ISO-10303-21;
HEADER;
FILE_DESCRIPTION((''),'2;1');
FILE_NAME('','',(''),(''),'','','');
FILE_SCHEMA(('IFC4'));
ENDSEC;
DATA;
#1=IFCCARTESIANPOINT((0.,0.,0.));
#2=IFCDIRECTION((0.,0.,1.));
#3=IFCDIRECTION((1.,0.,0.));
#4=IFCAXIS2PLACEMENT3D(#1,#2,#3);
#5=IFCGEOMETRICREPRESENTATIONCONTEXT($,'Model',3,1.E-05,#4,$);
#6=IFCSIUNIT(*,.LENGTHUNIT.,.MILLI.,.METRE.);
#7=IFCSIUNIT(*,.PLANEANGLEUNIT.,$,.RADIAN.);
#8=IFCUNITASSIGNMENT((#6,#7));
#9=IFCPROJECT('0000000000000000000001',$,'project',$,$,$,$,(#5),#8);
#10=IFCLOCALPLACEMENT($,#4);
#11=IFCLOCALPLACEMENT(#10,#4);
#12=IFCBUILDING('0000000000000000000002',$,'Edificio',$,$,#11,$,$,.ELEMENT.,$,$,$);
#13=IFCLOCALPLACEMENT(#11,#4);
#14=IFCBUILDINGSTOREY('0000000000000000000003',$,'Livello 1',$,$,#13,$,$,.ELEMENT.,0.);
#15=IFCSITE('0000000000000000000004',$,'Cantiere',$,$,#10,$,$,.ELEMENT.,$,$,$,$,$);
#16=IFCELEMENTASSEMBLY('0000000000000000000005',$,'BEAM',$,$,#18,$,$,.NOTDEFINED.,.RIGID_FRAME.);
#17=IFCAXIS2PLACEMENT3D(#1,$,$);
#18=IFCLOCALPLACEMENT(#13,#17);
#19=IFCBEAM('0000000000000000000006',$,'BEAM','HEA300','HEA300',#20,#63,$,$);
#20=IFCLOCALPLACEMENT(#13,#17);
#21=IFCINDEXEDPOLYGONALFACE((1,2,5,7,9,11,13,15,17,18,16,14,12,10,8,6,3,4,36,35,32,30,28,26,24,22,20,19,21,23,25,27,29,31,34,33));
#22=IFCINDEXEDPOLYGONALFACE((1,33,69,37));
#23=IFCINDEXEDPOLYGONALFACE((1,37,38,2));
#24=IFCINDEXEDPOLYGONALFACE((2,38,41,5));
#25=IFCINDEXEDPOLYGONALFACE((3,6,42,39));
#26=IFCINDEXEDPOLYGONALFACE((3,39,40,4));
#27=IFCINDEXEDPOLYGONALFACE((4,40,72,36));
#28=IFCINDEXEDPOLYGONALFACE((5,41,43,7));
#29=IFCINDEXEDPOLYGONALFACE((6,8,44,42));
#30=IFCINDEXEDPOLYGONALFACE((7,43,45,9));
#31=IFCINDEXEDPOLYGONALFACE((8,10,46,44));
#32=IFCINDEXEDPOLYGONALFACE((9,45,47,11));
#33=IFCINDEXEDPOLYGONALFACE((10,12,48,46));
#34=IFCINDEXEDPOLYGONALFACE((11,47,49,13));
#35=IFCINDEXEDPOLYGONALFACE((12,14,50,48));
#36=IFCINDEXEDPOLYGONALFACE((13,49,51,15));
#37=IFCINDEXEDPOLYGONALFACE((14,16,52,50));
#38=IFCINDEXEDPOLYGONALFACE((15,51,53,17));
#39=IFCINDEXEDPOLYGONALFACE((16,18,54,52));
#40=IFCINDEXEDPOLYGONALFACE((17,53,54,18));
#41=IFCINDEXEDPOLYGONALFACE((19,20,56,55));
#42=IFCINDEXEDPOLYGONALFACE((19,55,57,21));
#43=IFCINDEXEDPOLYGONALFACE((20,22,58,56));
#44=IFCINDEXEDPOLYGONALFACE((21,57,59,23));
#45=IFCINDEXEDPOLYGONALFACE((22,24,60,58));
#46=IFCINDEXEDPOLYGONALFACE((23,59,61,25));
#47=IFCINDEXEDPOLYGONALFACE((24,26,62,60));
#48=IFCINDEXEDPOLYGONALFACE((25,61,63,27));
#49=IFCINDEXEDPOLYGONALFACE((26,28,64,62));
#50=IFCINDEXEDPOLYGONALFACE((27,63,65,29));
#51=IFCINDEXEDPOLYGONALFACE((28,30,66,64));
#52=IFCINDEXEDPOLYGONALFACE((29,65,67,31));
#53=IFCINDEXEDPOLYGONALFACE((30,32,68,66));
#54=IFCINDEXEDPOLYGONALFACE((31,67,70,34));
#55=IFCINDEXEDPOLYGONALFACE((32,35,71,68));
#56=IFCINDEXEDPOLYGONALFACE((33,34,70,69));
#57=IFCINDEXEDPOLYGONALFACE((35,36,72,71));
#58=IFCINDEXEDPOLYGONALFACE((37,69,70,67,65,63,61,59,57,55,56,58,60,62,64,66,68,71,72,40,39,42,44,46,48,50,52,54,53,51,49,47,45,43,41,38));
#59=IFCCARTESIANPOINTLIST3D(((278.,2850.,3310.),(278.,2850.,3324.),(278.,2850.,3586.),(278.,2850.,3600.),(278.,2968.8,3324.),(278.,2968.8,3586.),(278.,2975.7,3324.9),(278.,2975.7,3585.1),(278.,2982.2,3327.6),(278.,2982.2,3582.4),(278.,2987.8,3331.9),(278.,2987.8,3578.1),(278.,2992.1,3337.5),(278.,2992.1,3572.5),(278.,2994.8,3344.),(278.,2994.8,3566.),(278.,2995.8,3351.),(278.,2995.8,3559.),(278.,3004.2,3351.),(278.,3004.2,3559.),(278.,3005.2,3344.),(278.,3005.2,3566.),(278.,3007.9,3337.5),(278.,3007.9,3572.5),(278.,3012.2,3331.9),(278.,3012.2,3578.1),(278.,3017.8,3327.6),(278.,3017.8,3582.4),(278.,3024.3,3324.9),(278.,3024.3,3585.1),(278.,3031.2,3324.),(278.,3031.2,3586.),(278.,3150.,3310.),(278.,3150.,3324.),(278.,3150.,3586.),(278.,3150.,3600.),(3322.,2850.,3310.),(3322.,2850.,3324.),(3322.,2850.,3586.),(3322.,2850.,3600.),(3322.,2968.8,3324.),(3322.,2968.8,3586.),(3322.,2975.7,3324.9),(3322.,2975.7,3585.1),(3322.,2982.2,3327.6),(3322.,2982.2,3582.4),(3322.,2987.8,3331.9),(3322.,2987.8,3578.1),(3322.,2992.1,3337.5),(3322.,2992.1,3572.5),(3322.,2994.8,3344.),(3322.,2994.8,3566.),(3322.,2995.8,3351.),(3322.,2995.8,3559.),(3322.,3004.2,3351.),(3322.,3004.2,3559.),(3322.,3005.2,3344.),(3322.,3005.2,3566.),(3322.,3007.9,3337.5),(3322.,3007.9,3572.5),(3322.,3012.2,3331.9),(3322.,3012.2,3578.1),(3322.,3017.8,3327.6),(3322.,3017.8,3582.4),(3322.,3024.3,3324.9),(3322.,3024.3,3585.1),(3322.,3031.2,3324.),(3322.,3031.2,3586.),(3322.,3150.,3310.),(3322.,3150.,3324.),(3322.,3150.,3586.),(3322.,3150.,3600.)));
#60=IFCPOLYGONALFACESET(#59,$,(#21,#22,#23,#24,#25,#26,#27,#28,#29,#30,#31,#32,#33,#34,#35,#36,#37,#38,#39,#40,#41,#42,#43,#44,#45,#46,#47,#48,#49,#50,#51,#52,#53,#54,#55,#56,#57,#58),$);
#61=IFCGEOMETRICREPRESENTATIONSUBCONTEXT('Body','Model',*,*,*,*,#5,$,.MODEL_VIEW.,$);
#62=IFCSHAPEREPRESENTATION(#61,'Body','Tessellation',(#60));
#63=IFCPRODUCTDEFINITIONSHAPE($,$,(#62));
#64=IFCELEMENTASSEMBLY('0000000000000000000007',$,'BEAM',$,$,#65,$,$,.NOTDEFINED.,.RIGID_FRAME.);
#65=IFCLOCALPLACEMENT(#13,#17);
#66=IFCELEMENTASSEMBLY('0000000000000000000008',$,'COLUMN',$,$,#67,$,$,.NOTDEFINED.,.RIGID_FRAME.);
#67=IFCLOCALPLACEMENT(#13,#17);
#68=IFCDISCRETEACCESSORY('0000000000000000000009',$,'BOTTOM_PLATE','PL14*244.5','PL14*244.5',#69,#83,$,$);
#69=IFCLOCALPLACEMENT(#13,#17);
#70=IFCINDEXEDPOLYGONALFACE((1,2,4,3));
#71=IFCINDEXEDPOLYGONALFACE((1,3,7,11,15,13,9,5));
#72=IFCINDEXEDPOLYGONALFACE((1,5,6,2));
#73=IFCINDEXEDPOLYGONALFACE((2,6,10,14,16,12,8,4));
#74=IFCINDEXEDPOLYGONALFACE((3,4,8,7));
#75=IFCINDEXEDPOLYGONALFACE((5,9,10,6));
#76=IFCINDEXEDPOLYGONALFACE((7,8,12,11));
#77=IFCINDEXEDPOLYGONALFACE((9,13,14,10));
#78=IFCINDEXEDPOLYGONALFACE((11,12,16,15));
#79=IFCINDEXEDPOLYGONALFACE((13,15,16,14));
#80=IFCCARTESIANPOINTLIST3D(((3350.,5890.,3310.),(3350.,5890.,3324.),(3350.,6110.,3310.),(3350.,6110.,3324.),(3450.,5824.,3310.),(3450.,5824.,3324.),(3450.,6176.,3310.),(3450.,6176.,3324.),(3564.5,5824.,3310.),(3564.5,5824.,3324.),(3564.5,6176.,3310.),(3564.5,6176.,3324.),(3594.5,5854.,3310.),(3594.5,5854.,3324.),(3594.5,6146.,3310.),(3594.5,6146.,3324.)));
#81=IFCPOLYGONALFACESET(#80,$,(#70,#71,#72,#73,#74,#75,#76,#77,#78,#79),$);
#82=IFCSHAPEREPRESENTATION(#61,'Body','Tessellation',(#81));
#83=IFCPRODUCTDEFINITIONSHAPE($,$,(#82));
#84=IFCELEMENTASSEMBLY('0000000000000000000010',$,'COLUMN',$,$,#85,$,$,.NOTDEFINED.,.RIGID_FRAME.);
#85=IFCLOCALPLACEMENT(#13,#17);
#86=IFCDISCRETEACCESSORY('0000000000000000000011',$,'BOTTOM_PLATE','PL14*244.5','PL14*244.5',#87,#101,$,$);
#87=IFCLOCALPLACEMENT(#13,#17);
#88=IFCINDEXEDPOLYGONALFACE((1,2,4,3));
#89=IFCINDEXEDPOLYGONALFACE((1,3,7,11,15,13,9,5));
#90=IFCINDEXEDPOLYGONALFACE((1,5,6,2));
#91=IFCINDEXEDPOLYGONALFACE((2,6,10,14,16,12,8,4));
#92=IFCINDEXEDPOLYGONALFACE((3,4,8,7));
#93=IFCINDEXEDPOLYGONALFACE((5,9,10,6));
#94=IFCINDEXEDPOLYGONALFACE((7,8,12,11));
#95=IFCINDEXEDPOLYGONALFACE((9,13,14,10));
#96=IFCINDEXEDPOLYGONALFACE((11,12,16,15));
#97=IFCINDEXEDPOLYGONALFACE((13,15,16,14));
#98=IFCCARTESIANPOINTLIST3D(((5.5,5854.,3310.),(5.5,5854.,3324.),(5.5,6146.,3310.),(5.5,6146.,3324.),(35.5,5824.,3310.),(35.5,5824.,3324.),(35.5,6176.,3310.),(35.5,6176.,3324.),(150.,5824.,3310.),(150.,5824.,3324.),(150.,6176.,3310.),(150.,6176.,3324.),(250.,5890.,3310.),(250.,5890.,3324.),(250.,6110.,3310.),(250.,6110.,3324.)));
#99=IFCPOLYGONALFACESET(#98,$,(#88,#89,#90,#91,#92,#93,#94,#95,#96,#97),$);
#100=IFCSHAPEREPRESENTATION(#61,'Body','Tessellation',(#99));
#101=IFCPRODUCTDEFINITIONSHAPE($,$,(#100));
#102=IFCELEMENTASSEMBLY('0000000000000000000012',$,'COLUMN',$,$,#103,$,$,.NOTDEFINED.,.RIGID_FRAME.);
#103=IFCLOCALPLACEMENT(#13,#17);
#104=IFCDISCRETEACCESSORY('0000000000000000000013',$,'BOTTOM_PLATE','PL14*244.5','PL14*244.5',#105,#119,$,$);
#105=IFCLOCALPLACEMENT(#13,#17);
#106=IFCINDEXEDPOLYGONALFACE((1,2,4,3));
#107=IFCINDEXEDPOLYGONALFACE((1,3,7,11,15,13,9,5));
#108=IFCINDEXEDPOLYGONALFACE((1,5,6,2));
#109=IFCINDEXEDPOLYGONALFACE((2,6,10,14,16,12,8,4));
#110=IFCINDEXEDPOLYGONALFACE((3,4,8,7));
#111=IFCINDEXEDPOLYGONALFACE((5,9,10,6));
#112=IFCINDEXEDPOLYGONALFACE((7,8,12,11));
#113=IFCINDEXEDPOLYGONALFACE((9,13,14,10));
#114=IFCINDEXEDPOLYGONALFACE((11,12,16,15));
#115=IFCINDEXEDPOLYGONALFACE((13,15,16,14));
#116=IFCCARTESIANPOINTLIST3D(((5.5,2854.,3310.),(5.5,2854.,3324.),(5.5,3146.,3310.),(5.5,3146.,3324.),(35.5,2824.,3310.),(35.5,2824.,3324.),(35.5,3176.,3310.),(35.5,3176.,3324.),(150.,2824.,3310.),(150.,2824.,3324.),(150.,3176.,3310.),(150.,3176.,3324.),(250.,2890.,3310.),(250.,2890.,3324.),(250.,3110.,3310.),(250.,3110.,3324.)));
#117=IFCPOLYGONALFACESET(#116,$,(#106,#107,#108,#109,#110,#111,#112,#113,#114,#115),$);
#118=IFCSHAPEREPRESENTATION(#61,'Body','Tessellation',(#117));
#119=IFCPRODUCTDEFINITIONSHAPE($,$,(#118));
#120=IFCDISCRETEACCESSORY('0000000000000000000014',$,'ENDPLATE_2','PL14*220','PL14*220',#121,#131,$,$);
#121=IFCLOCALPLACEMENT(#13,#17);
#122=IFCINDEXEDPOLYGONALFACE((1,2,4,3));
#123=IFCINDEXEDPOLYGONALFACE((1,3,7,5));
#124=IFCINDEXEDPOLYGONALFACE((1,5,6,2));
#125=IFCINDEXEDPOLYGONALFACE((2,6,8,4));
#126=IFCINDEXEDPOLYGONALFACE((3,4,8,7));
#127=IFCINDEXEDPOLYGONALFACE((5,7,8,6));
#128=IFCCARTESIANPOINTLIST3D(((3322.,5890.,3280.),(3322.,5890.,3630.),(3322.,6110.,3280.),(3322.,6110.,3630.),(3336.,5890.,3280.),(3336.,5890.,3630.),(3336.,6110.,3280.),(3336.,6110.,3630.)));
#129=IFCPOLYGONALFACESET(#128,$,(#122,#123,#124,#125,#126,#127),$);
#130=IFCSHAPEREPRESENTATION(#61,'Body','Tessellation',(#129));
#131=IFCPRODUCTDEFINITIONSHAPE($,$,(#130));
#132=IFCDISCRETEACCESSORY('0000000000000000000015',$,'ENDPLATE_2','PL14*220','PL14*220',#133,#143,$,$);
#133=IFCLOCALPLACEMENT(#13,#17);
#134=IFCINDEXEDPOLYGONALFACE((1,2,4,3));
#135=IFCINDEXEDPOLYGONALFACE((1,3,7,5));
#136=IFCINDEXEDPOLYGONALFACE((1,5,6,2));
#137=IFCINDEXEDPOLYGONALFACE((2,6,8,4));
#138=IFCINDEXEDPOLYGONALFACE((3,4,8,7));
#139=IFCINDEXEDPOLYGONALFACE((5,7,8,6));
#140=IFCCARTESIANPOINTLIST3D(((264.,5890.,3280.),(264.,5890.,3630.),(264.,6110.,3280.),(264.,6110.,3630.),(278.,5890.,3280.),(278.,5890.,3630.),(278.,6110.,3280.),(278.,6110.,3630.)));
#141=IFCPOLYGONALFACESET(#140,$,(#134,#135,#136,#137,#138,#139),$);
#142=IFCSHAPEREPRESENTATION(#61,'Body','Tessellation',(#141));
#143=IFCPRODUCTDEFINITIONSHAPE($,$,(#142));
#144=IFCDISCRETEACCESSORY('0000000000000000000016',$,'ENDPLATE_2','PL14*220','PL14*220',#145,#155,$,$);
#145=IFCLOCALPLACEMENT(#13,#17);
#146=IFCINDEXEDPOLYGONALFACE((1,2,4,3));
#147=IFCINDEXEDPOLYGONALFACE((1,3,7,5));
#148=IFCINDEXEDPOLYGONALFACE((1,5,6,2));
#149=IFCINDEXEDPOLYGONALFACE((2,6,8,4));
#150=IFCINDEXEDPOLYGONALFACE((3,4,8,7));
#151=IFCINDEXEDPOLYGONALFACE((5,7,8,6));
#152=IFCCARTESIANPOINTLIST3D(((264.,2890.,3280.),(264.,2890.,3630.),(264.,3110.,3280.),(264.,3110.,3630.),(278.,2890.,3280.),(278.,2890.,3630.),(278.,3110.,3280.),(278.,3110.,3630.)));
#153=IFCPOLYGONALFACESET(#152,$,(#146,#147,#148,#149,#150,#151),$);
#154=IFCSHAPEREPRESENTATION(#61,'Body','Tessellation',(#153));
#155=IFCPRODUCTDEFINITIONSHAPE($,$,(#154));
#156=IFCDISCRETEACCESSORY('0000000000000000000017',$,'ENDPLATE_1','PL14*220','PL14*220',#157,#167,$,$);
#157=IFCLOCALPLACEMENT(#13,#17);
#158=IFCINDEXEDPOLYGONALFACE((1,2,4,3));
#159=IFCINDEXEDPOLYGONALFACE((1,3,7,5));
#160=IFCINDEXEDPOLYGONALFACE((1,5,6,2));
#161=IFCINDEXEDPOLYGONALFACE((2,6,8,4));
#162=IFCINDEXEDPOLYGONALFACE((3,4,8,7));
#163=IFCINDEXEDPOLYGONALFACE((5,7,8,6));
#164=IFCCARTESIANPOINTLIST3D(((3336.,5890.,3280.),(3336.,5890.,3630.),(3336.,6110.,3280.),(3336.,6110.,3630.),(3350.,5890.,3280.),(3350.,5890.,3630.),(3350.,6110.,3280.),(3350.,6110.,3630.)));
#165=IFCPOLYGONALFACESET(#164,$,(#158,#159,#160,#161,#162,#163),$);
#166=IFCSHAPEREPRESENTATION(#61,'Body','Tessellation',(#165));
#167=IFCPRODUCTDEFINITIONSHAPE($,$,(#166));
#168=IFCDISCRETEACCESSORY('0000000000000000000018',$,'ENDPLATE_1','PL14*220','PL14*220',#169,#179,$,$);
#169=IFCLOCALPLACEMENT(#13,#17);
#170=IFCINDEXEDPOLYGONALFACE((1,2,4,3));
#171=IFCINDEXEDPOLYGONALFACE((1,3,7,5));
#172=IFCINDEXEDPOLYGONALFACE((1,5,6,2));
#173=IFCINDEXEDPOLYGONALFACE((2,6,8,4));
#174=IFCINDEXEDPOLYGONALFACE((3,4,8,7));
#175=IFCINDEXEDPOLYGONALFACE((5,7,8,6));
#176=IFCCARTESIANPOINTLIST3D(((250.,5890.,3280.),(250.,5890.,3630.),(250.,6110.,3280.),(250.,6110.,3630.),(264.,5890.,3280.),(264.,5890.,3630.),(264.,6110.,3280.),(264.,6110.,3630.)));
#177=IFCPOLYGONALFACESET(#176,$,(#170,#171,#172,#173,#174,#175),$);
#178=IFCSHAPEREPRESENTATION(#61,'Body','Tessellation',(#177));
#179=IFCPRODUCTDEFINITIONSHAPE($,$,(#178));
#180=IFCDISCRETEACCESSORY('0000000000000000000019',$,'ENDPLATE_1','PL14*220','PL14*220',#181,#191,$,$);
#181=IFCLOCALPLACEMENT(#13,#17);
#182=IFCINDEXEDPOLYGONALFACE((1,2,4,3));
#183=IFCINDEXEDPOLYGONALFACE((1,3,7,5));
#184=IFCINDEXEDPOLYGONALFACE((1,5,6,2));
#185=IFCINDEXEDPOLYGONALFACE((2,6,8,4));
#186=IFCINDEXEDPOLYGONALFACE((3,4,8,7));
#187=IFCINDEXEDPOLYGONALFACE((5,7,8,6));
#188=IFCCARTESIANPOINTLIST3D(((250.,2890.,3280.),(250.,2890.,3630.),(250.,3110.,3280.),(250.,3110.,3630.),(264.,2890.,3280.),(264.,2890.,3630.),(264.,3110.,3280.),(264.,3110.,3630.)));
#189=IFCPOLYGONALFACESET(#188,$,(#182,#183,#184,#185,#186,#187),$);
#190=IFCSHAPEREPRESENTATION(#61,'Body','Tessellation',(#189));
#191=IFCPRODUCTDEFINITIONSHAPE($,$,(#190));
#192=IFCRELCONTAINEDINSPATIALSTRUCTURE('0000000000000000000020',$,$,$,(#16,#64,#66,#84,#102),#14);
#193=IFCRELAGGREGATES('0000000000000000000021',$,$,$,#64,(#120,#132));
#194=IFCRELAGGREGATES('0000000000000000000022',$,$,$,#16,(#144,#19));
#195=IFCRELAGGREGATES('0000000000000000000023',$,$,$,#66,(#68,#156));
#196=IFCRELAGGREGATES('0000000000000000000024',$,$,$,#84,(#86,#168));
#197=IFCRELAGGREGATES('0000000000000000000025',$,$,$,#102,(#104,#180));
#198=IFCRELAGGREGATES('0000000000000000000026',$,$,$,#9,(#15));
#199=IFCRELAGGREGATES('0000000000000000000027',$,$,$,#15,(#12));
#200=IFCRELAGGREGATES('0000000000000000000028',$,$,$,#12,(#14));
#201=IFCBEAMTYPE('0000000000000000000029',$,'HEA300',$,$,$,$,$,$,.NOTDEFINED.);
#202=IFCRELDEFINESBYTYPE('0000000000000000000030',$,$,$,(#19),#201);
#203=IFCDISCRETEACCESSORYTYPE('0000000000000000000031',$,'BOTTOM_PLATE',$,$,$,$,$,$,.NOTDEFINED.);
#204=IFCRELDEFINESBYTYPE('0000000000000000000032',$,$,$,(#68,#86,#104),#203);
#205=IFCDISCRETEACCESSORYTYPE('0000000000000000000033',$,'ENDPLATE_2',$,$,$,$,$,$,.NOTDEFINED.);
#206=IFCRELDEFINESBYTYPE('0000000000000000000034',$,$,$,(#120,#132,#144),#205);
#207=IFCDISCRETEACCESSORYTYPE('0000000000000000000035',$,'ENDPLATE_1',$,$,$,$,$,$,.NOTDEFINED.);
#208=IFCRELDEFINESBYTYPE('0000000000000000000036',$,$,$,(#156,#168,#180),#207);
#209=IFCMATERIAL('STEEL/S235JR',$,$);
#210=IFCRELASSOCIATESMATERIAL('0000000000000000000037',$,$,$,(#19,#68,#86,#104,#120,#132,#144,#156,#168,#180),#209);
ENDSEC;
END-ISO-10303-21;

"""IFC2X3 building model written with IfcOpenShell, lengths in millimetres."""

from ifc_helpers import new_model, si_unit, frame, origin_with_axes, origin_2d_with_axis, place, context, subcontext, project, spatial, polyline, i_section, outline, extrude, clip, halfspace, material, type_object, element, aggregate, save


model = new_model("IFC2X3")

# Units and contexts
model_context = context("Model", 3, precision=1e-05, world=origin_with_axes())
body_context = subcontext(model_context, "Body", "Model", "MODEL_VIEW")
ifc_project = project(units=[si_unit("LENGTHUNIT", "METRE", prefix="MILLI"), si_unit("PLANEANGLEUNIT", "RADIAN")], contexts=[model_context])

# Site, building, storey
site_placement = place(None, origin_with_axes())
site = spatial("IfcSite", under=ifc_project, at=site_placement, Name="Cantiere", CompositionType="ELEMENT")
building_placement = place(site_placement, origin_with_axes())
building = spatial("IfcBuilding", under=site, at=building_placement, Name="Edificio", CompositionType="ELEMENT")
storey_placement = place(building_placement, origin_with_axes())
storey = spatial("IfcBuildingStorey", under=building, at=storey_placement, Name="Livello 1", CompositionType="ELEMENT", Elevation=0.0)

# Element assembly, beam
ifc_material_1 = material(Name="STEEL/S235JR")
beam_type = type_object("IfcBeamType", Name="HEA300", PredefinedType="NOTDEFINED")
assembly_1_placement = place(storey_placement, origin_with_axes())
assembly_1 = element("IfcElementAssembly", 1, at=assembly_1_placement, inside=storey, Name="BEAM", AssemblyPlace="NOTDEFINED", PredefinedType="RIGID_FRAME")
beam_1_placement = place(assembly_1_placement, frame((0.0, 3000.0, 3455.0), z_axis=(0.0, 0.0, 1.0), x_axis=(1.0, 0.0, 0.0)))
beam_1 = element("IfcBeam", 2, at=beam_1_placement, type_object=beam_type, material=ifc_material_1, Name="BEAM", Description="HEA300", ObjectType="HEA300", context=body_context, shape_type="Clipping", body=[
    clip(clip(extrude(i_section(OverallWidth=300.0, OverallDepth=290.0, WebThickness=8.5, FlangeThickness=14.0, FilletRadius=27.0, at=origin_2d_with_axis()), frame((3322.0, 0.0, 0.0), z_axis=(-1.0, 0.0, 0.0), x_axis=(0.0, -1.0, 0.0)), (0.0, 0.0, 1.0), 3044.0), halfspace(frame((3322.0, -150.0, 0.0), z_axis=(1.0, 0.0, 0.0), x_axis=(0.0, 0.0, 1.0)), False)), halfspace(frame((278.0, 150.0, 0.0), z_axis=(-1.0, 0.0, 0.0), x_axis=(0.0, 0.0, 1.0)), False)),
])

# Element assembly
assembly_2_placement = place(storey_placement, origin_with_axes())
assembly_2 = element("IfcElementAssembly", 3, at=assembly_2_placement, inside=storey, Name="BEAM", AssemblyPlace="NOTDEFINED", PredefinedType="RIGID_FRAME")

# Element assemblies, discrete accessories
assembly_3_placement = place(storey_placement, origin_with_axes())
assembly_3 = element("IfcElementAssembly", 4, at=assembly_3_placement, inside=storey, Name="COLUMN", AssemblyPlace="NOTDEFINED", PredefinedType="RIGID_FRAME")
discrete_accessory_type_1 = type_object("IfcDiscreteAccessoryType", Name="BOTTOM_PLATE")
discrete_accessory_1_placement = place(assembly_3_placement, frame((3594.5, 5824.0, 3317.0), z_axis=(0.0, 0.0, 1.0), x_axis=(0.0, 1.0, 0.0)))
discrete_accessory_1 = element("IfcDiscreteAccessory", 5, at=discrete_accessory_1_placement, type_object=discrete_accessory_type_1, material=ifc_material_1, Name="BOTTOM_PLATE", Description="PL14*244.5", ObjectType="PL14*244.5", context=body_context, shape_type="SweptSolid", body=[
    extrude(outline(polyline([(0.0, 30.0), (30.0, 0.0), (322.0, 0.0), (352.0, 30.0), (352.0, 144.5), (286.0, 244.5), (66.0, 244.5), (0.0, 144.5), (0.0, 30.0)])), frame((0.0, 0.0, -7.0), z_axis=(0.0, 0.0, 1.0), x_axis=(1.0, 0.0, 0.0)), (0.0, 0.0, 1.0), 14.0),
])
assembly_4_placement = place(storey_placement, origin_with_axes())
assembly_4 = element("IfcElementAssembly", 6, at=assembly_4_placement, inside=storey, Name="COLUMN", AssemblyPlace="NOTDEFINED", PredefinedType="RIGID_FRAME")
discrete_accessory_2_placement = place(assembly_4_placement, frame((5.5, 6176.0, 3317.0), z_axis=(0.0, 0.0, 1.0), x_axis=(0.0, -1.0, 0.0)))
discrete_accessory_2 = element("IfcDiscreteAccessory", 7, at=discrete_accessory_2_placement, type_object=discrete_accessory_type_1, material=ifc_material_1, Name="BOTTOM_PLATE", Description="PL14*244.5", ObjectType="PL14*244.5", context=body_context, shape_type="SweptSolid", body=[
    extrude(outline(polyline([(0.0, 30.0), (30.0, 0.0), (322.0, 0.0), (352.0, 30.0), (352.0, 144.5), (286.0, 244.5), (66.0, 244.5), (0.0, 144.5), (0.0, 30.0)])), frame((0.0, 0.0, -7.0), z_axis=(0.0, 0.0, 1.0), x_axis=(1.0, 0.0, 0.0)), (0.0, 0.0, 1.0), 14.0),
])
assembly_5_placement = place(storey_placement, origin_with_axes())
assembly_5 = element("IfcElementAssembly", 8, at=assembly_5_placement, inside=storey, Name="COLUMN", AssemblyPlace="NOTDEFINED", PredefinedType="RIGID_FRAME")
discrete_accessory_3_placement = place(assembly_5_placement, frame((5.5, 3176.0, 3317.0), z_axis=(0.0, 0.0, 1.0), x_axis=(0.0, -1.0, 0.0)))
discrete_accessory_3 = element("IfcDiscreteAccessory", 9, at=discrete_accessory_3_placement, type_object=discrete_accessory_type_1, material=ifc_material_1, Name="BOTTOM_PLATE", Description="PL14*244.5", ObjectType="PL14*244.5", context=body_context, shape_type="SweptSolid", body=[
    extrude(outline(polyline([(0.0, 30.0), (30.0, 0.0), (322.0, 0.0), (352.0, 30.0), (352.0, 144.5), (286.0, 244.5), (66.0, 244.5), (0.0, 144.5), (0.0, 30.0)])), frame((0.0, 0.0, -7.0), z_axis=(0.0, 0.0, 1.0), x_axis=(1.0, 0.0, 0.0)), (0.0, 0.0, 1.0), 14.0),
])

# Discrete accessories
discrete_accessory_type_2 = type_object("IfcDiscreteAccessoryType", Name="ENDPLATE_2")
discrete_accessory_4_placement = place(assembly_2_placement, frame((3329.0, 5890.0, 3280.0), z_axis=(-1.0, 0.0, 0.0), x_axis=(0.0, 0.0, 1.0)))
discrete_accessory_4 = element("IfcDiscreteAccessory", 10, at=discrete_accessory_4_placement, type_object=discrete_accessory_type_2, material=ifc_material_1, Name="ENDPLATE_2", Description="PL14*220", ObjectType="PL14*220", context=body_context, shape_type="SweptSolid", body=[
    extrude(outline(polyline([(0.0, 0.0), (350.0, 0.0), (350.0, 220.0), (0.0, 220.0), (0.0, 0.0)])), frame((0.0, 0.0, -7.0), z_axis=(0.0, 0.0, 1.0), x_axis=(1.0, 0.0, 0.0)), (0.0, 0.0, 1.0), 14.0),
])
discrete_accessory_5_placement = place(assembly_2_placement, frame((271.0, 6110.0, 3280.0), z_axis=(1.0, 0.0, 0.0), x_axis=(0.0, 0.0, 1.0)))
discrete_accessory_5 = element("IfcDiscreteAccessory", 11, at=discrete_accessory_5_placement, type_object=discrete_accessory_type_2, material=ifc_material_1, Name="ENDPLATE_2", Description="PL14*220", ObjectType="PL14*220", context=body_context, shape_type="SweptSolid", body=[
    extrude(outline(polyline([(0.0, 0.0), (350.0, 0.0), (350.0, 220.0), (0.0, 220.0), (0.0, 0.0)])), frame((0.0, 0.0, -7.0), z_axis=(0.0, 0.0, 1.0), x_axis=(1.0, 0.0, 0.0)), (0.0, 0.0, 1.0), 14.0),
])
aggregate(assembly_2, [discrete_accessory_4, discrete_accessory_5])
discrete_accessory_6_placement = place(assembly_1_placement, frame((271.0, 3110.0, 3280.0), z_axis=(1.0, 0.0, 0.0), x_axis=(0.0, 0.0, 1.0)))
discrete_accessory_6 = element("IfcDiscreteAccessory", 12, at=discrete_accessory_6_placement, type_object=discrete_accessory_type_2, material=ifc_material_1, Name="ENDPLATE_2", Description="PL14*220", ObjectType="PL14*220", context=body_context, shape_type="SweptSolid", body=[
    extrude(outline(polyline([(0.0, 0.0), (350.0, 0.0), (350.0, 220.0), (0.0, 220.0), (0.0, 0.0)])), frame((0.0, 0.0, -7.0), z_axis=(0.0, 0.0, 1.0), x_axis=(1.0, 0.0, 0.0)), (0.0, 0.0, 1.0), 14.0),
])
aggregate(assembly_1, [discrete_accessory_6, beam_1])
discrete_accessory_type_3 = type_object("IfcDiscreteAccessoryType", Name="ENDPLATE_1")
discrete_accessory_7_placement = place(assembly_3_placement, frame((3343.0, 5890.0, 3280.0), z_axis=(-1.0, 0.0, 0.0), x_axis=(0.0, 0.0, 1.0)))
discrete_accessory_7 = element("IfcDiscreteAccessory", 13, at=discrete_accessory_7_placement, type_object=discrete_accessory_type_3, material=ifc_material_1, Name="ENDPLATE_1", Description="PL14*220", ObjectType="PL14*220", context=body_context, shape_type="SweptSolid", body=[
    extrude(outline(polyline([(0.0, 0.0), (350.0, 0.0), (350.0, 220.0), (0.0, 220.0), (0.0, 0.0)])), frame((0.0, 0.0, -7.0), z_axis=(0.0, 0.0, 1.0), x_axis=(1.0, 0.0, 0.0)), (0.0, 0.0, 1.0), 14.0),
])
aggregate(assembly_3, [discrete_accessory_1, discrete_accessory_7])
discrete_accessory_8_placement = place(assembly_4_placement, frame((257.0, 6110.0, 3280.0), z_axis=(1.0, 0.0, 0.0), x_axis=(0.0, 0.0, 1.0)))
discrete_accessory_8 = element("IfcDiscreteAccessory", 14, at=discrete_accessory_8_placement, type_object=discrete_accessory_type_3, material=ifc_material_1, Name="ENDPLATE_1", Description="PL14*220", ObjectType="PL14*220", context=body_context, shape_type="SweptSolid", body=[
    extrude(outline(polyline([(0.0, 0.0), (350.0, 0.0), (350.0, 220.0), (0.0, 220.0), (0.0, 0.0)])), frame((0.0, 0.0, -7.0), z_axis=(0.0, 0.0, 1.0), x_axis=(1.0, 0.0, 0.0)), (0.0, 0.0, 1.0), 14.0),
])
aggregate(assembly_4, [discrete_accessory_2, discrete_accessory_8])
discrete_accessory_9_placement = place(assembly_5_placement, frame((257.0, 3110.0, 3280.0), z_axis=(1.0, 0.0, 0.0), x_axis=(0.0, 0.0, 1.0)))
discrete_accessory_9 = element("IfcDiscreteAccessory", 15, at=discrete_accessory_9_placement, type_object=discrete_accessory_type_3, material=ifc_material_1, Name="ENDPLATE_1", Description="PL14*220", ObjectType="PL14*220", context=body_context, shape_type="SweptSolid", body=[
    extrude(outline(polyline([(0.0, 0.0), (350.0, 0.0), (350.0, 220.0), (0.0, 220.0), (0.0, 0.0)])), frame((0.0, 0.0, -7.0), z_axis=(0.0, 0.0, 1.0), x_axis=(1.0, 0.0, 0.0)), (0.0, 0.0, 1.0), 14.0),
])
aggregate(assembly_5, [discrete_accessory_3, discrete_accessory_9])

save(model, "model.ifc")
